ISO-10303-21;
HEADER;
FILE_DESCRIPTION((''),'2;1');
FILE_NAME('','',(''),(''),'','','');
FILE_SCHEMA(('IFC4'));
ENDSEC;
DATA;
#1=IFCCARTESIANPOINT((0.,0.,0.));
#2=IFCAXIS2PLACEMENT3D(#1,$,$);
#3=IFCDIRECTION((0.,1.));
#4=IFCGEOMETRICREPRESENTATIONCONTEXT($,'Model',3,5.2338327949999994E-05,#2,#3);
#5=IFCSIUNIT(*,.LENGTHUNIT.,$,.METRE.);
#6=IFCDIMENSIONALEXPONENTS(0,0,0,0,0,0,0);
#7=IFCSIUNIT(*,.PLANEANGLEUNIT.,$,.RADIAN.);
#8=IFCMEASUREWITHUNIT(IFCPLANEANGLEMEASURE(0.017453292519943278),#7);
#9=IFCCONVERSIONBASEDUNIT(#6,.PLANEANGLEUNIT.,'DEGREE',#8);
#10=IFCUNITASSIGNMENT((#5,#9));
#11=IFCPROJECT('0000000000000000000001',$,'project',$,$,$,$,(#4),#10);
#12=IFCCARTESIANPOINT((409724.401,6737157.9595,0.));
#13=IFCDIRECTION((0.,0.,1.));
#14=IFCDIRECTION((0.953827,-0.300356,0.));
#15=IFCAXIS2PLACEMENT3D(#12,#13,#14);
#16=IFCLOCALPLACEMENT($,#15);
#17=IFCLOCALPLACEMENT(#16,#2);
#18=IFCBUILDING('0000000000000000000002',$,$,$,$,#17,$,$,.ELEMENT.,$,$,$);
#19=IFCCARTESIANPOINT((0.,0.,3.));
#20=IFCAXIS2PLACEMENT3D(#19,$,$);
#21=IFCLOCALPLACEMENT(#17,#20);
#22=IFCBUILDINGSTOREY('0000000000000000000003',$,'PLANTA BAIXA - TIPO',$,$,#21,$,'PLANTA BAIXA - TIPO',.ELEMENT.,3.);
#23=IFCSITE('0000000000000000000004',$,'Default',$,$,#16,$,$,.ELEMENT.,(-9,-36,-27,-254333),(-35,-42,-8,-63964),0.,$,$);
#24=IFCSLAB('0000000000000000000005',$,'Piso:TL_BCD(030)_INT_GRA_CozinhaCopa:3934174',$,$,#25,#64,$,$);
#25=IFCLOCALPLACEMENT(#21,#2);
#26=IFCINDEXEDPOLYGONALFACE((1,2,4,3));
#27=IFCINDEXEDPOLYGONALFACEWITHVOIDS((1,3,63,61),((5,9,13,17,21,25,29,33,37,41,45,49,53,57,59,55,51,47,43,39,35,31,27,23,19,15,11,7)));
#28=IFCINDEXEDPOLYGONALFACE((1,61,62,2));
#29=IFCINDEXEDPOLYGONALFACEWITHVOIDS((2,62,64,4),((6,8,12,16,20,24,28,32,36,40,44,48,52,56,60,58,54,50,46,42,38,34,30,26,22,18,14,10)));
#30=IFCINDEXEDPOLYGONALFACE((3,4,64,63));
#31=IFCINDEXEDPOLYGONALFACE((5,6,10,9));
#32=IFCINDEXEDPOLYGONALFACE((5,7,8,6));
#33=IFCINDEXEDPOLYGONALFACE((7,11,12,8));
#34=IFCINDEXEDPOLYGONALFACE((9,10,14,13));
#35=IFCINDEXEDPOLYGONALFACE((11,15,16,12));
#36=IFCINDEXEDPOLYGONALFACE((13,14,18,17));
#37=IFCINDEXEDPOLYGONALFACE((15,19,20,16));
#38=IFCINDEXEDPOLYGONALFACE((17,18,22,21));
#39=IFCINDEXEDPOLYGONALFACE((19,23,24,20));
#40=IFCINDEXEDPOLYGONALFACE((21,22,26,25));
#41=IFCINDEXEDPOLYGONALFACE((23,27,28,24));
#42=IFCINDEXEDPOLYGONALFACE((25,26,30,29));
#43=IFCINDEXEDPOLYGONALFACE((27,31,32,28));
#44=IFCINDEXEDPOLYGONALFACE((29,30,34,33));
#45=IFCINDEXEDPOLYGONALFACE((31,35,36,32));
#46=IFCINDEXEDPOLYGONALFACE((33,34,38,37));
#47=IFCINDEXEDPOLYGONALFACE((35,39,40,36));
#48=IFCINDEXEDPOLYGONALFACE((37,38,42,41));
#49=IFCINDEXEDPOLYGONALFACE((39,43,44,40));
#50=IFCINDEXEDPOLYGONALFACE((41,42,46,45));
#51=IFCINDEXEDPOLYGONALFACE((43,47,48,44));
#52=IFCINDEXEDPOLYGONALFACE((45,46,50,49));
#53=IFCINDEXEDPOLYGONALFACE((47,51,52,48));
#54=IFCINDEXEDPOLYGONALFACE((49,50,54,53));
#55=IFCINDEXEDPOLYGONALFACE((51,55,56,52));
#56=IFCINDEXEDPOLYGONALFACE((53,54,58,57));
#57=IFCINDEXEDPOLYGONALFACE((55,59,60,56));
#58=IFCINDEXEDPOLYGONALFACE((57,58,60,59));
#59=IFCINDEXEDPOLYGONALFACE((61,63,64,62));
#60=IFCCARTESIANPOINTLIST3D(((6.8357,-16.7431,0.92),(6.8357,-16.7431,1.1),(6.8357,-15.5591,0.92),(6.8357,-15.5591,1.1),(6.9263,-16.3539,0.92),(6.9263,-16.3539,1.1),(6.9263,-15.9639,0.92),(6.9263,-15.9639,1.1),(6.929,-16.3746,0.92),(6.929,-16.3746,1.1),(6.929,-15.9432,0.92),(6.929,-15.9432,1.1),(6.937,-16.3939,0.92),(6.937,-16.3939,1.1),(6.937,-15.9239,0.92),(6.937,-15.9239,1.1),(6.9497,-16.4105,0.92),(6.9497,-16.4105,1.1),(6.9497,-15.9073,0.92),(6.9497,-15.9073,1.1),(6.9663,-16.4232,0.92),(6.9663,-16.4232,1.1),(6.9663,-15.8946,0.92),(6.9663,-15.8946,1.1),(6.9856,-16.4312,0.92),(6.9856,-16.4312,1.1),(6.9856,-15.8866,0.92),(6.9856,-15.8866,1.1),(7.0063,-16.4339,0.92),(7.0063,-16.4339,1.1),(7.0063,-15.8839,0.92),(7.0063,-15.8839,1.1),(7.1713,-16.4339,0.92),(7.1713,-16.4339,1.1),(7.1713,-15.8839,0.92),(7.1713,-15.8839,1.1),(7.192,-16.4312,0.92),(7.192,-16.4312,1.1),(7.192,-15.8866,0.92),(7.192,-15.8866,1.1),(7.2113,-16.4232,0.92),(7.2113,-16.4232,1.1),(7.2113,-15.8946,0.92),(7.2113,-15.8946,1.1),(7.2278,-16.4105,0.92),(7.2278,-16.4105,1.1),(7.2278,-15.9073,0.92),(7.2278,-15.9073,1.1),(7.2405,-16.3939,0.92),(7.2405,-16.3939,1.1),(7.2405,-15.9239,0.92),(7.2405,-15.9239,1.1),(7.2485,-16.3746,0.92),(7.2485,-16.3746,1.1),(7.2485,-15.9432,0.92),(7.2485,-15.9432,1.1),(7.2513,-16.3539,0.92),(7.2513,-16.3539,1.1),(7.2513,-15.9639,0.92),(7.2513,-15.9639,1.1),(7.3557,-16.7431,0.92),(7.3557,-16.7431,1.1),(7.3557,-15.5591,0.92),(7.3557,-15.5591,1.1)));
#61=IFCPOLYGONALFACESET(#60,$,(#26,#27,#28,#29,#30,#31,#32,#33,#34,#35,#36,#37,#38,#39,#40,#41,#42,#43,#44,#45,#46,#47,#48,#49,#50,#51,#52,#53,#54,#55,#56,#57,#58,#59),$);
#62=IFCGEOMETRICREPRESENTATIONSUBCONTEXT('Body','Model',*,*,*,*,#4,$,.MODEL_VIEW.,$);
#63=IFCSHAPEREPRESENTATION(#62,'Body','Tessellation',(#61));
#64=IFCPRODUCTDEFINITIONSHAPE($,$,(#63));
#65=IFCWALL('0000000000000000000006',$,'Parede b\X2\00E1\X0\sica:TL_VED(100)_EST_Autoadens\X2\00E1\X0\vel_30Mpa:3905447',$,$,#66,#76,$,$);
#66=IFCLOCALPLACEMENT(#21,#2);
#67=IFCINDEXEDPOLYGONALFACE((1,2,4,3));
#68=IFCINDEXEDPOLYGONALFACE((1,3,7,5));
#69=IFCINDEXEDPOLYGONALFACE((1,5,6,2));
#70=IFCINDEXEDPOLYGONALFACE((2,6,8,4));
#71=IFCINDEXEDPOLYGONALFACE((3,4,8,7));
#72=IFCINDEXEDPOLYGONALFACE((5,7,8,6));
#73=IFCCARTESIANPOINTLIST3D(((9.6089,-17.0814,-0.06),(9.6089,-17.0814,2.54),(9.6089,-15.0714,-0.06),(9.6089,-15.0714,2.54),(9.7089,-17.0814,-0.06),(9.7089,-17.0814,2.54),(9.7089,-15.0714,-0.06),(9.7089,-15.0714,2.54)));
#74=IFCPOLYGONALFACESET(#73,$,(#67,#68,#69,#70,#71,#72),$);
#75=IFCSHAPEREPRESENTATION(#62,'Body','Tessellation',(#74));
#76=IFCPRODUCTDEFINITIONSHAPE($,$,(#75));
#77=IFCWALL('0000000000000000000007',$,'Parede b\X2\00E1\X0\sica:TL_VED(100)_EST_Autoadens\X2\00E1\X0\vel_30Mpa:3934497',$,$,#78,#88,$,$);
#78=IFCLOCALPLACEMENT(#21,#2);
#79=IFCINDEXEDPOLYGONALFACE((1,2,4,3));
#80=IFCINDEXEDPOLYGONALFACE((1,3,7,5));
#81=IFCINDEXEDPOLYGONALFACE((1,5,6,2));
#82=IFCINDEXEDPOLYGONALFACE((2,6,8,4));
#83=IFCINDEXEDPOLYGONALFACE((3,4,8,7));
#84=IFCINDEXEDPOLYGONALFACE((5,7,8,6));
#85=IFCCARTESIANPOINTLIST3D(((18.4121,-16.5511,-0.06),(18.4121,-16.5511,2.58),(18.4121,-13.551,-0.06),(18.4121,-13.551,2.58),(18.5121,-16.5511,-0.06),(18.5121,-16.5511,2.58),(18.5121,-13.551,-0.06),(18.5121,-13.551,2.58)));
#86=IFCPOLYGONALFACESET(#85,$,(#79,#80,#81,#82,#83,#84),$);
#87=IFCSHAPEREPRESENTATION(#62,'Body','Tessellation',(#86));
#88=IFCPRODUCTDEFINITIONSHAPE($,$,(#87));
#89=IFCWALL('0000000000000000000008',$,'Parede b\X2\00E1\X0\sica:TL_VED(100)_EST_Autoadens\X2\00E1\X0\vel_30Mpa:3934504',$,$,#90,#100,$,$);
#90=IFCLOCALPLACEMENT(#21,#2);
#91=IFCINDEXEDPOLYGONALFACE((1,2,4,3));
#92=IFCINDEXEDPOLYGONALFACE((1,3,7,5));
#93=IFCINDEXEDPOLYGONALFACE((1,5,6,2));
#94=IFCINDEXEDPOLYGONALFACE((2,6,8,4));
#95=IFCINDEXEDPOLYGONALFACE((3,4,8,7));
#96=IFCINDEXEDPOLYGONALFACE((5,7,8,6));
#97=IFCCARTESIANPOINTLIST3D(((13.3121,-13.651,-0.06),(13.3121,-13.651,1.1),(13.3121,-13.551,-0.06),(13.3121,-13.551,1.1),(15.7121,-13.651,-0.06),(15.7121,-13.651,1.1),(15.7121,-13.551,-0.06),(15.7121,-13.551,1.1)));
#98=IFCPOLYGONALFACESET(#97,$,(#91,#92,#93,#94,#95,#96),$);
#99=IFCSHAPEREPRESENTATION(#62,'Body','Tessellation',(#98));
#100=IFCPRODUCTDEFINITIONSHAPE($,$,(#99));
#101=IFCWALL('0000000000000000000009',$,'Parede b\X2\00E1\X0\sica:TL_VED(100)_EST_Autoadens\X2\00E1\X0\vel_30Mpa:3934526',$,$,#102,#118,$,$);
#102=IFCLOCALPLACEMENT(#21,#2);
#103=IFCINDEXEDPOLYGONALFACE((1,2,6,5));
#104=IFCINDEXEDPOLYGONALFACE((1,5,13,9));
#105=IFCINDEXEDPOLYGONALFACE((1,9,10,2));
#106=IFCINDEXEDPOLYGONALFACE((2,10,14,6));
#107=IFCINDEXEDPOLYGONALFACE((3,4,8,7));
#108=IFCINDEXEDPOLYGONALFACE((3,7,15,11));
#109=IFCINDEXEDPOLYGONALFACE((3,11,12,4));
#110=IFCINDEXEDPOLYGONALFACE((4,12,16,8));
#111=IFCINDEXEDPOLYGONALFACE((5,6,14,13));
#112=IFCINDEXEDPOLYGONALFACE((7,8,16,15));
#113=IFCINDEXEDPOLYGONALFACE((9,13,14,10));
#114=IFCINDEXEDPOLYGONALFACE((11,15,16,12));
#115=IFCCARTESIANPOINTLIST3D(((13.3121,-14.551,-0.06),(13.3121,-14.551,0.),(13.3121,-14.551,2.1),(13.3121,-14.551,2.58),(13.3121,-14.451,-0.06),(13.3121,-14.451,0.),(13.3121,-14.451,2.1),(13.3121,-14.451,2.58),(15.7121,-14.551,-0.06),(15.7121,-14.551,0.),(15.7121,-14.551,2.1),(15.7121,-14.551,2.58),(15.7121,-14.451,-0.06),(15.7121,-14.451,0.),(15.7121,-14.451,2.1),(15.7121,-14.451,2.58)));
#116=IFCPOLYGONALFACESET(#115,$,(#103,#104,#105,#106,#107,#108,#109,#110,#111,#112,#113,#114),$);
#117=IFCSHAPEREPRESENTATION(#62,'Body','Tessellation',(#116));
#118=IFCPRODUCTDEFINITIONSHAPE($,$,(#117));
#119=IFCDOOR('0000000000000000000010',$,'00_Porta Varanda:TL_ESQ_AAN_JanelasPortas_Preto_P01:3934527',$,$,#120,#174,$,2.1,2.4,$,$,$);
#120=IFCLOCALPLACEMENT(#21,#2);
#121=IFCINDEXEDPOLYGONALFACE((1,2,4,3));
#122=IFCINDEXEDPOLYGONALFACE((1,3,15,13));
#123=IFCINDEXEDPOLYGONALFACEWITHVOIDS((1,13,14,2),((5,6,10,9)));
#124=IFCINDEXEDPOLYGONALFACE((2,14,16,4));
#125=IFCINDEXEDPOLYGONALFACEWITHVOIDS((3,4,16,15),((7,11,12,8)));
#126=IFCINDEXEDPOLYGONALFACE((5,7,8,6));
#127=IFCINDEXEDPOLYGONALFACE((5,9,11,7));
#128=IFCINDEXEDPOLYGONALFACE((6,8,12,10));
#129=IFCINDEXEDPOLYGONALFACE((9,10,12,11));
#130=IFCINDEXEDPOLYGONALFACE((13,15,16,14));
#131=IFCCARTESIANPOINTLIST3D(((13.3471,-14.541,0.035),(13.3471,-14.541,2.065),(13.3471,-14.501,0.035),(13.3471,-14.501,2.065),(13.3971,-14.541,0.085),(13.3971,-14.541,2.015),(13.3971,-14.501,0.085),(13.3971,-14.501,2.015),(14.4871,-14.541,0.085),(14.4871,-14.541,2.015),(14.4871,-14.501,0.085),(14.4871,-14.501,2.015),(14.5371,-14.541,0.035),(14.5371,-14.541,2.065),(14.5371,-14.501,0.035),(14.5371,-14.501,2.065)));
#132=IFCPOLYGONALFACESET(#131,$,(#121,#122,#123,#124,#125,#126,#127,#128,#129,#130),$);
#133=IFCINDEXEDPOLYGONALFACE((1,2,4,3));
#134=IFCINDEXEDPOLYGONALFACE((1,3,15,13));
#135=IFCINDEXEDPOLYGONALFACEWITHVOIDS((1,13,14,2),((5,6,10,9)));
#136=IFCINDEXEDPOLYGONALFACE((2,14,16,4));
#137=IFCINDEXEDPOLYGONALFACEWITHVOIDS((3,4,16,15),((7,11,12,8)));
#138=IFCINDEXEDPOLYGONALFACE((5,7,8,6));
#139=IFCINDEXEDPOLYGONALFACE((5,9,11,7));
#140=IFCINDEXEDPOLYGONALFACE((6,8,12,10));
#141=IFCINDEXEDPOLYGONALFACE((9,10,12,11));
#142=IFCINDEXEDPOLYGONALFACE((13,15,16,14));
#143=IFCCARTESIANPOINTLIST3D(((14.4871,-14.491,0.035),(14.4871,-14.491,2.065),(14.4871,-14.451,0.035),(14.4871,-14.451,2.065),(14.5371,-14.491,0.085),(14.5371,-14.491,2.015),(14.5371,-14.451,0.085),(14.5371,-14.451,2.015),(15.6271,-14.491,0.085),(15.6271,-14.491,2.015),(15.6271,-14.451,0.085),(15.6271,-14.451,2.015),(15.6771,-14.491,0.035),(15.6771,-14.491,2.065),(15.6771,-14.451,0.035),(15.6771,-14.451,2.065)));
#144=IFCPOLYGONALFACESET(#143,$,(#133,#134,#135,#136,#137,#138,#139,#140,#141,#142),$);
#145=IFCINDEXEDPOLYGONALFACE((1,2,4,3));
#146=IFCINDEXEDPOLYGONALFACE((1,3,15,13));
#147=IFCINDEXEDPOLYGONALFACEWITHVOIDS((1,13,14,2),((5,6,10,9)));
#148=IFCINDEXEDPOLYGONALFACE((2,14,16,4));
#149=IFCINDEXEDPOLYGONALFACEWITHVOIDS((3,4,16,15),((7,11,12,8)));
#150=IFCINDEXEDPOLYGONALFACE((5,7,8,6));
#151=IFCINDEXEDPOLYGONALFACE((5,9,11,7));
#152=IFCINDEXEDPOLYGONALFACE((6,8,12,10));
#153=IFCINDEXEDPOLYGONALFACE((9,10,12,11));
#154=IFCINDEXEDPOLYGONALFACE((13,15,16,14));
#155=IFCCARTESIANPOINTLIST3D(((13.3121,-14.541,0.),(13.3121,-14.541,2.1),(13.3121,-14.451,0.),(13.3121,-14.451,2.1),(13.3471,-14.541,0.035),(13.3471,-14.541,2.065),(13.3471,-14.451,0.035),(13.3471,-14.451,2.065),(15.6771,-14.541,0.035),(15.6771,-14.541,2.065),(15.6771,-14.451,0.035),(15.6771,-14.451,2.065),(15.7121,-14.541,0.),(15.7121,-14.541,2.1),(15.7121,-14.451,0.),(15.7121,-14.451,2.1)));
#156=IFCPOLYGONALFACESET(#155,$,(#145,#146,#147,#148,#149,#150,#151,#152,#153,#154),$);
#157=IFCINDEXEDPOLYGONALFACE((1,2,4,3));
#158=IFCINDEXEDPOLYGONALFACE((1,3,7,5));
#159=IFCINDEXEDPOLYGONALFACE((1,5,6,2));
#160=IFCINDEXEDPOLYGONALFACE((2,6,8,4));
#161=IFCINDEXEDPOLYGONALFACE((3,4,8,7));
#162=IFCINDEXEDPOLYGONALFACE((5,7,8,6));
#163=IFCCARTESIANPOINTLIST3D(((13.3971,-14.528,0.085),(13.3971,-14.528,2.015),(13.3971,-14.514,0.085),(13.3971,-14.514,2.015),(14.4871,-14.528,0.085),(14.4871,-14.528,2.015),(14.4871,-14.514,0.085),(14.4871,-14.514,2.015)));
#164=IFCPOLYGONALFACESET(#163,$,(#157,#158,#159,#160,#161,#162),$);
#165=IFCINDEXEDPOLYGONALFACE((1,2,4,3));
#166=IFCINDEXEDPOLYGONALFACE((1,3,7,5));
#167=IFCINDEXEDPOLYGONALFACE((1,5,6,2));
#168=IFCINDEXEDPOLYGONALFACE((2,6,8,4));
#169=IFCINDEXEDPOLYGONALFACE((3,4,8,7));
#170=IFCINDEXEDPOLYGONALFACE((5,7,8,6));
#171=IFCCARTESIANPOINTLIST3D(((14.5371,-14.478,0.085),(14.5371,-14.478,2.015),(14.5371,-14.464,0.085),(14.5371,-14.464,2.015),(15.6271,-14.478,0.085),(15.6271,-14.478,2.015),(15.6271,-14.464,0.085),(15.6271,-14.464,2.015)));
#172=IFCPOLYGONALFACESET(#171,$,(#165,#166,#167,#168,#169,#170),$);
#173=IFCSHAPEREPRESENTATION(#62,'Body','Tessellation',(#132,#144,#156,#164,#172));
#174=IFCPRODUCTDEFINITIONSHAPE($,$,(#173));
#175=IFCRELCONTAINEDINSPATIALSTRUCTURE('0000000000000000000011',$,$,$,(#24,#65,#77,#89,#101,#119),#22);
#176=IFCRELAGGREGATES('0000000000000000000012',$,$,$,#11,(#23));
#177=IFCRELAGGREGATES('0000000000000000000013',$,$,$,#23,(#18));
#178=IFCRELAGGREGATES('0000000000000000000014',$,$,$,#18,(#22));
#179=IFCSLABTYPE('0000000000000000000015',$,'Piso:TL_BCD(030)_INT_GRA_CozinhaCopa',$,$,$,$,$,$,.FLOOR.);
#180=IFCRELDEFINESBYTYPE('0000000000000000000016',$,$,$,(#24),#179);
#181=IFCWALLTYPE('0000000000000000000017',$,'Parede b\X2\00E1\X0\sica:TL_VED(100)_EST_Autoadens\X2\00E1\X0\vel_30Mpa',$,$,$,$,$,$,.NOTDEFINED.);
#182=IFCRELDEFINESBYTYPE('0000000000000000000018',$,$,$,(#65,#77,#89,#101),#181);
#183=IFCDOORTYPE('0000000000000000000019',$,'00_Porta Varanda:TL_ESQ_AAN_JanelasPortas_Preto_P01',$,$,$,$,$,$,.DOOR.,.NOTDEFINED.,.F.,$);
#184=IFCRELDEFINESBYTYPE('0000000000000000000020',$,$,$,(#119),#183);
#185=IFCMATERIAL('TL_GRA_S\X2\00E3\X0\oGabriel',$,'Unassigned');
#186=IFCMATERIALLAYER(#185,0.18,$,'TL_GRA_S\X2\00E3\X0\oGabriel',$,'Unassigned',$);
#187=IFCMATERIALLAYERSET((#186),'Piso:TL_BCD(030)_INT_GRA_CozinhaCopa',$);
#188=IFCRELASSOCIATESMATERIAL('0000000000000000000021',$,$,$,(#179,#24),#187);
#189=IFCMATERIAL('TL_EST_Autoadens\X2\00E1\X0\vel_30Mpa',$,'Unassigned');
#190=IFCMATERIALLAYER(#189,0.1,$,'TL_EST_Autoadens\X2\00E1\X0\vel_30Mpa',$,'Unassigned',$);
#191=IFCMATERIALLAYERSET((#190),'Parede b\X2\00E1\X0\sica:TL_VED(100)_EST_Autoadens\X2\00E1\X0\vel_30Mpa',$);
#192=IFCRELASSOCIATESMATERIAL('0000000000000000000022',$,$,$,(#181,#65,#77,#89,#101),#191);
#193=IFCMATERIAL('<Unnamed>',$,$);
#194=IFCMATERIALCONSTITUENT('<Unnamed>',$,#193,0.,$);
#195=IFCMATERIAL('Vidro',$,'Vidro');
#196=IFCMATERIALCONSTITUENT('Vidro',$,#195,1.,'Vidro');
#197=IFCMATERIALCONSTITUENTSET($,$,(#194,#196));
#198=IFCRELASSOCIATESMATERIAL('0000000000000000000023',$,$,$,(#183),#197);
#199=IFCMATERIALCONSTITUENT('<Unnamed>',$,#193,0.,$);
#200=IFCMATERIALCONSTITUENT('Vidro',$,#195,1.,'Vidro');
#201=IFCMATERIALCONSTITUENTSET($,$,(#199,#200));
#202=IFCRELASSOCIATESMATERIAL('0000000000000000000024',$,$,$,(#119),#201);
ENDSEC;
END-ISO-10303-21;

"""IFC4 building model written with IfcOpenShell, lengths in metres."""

from ifc_helpers import new_model, entity, si_unit, converted_unit, direction, frame, frame_2d, origin, place, context, subcontext, project, spatial, polyline, circle_curve, parameter, trimmed, segment, composite_curve, rectangle, outline, extrude, source, transform, mapped, material, layer, layer_set, layer_usage, constituent, constituent_set, type_object, type_shapes, element, fill, save


model = new_model("IFC4")

# Units and contexts
model_context = context("Model", 3, precision=5.2338327949999994e-05, world=origin(), true_north=direction((0.0, 1.0)))
body_context = subcontext(model_context, "Body", "Model", "MODEL_VIEW")
ifc_project = project(units=[si_unit("LENGTHUNIT", "METRE"), converted_unit("PLANEANGLEUNIT", "DEGREE", entity("IfcPlaneAngleMeasure", 0.017453292519943278), si_unit("PLANEANGLEUNIT", "RADIAN"), dimensions=[0, 0, 0, 0, 0, 0, 0])], contexts=[model_context])

# Site, building, storey
site_placement = place(None, frame((409724.401, 6737157.9595, 0.0), z_axis=(0.0, 0.0, 1.0), x_axis=(0.953827, -0.300356, 0.0)))
site = spatial("IfcSite", under=ifc_project, at=site_placement, Name="Default", CompositionType="ELEMENT", RefLatitude=(-9, -36, -27, -254333), RefLongitude=(-35, -42, -8, -63964), RefElevation=0.0)
building_placement = place(site_placement, origin())
building = spatial("IfcBuilding", under=site, at=building_placement, CompositionType="ELEMENT")
storey_placement = place(building_placement, frame((0.0, 0.0, 3.0)))
storey = spatial("IfcBuildingStorey", under=building, at=storey_placement, Name="PLANTA BAIXA - TIPO", LongName="PLANTA BAIXA - TIPO", CompositionType="ELEMENT", Elevation=3.0)

# Slab, opening
ifc_material_1 = material(Name="TL_GRA_SãoGabriel", Category="Unassigned")
ifc_layer_1 = layer(ifc_material_1, 0.18, Name="TL_GRA_SãoGabriel", Category="Unassigned")
ifc_layer_set_1 = layer_set([ifc_layer_1], Name="Piso:TL_BCD(030)_INT_GRA_CozinhaCopa")
ifc_layer_usage_1 = layer_usage(ifc_layer_set_1, "AXIS3", "POSITIVE", 0.0)
slab_type = type_object("IfcSlabType", Name="Piso:TL_BCD(030)_INT_GRA_CozinhaCopa", PredefinedType="FLOOR", material=ifc_layer_set_1)
slab_placement = place(storey_placement, frame((6.8357, -16.7431, 0.92)))
slab = element("IfcSlab", 1, at=slab_placement, inside=storey, type_object=slab_type, material=ifc_layer_usage_1, Name="Piso:TL_BCD(030)_INT_GRA_CozinhaCopa:3934174", context=body_context, shape_type="SweptSolid", body=[
    extrude(rectangle(XDim=1.184, YDim=0.52, at=frame_2d((0.0, 0.0), x_axis=(0.0, -1.0))), frame((0.26, 0.592, 0.18), z_axis=(0.0, 0.0, -1.0), x_axis=(-1.0, 0.0, 0.0)), (0.0, 0.0, 1.0), 0.18),
])
opening_1_placement = place(slab_placement, frame((-6.8357, 16.7431, 0.18)))
element("IfcOpeningElement", 2, at=opening_1_placement, cuts=slab, PredefinedType="OPENING", context=body_context, shape_type="SweptSolid", body=[
    extrude(outline(composite_curve([segment(polyline([(-0.195, -0.1625), (0.195, -0.1625)]), True, "CONTINUOUS"), segment(trimmed(circle_curve(frame_2d((0.195, -0.0825), x_axis=(-1.0, 0.0)), 0.08), [parameter(90.0)], [parameter(180.0)], True, "PARAMETER"), True, "CONTINUOUS"), segment(polyline([(0.275, -0.0825), (0.275, 0.0825)]), True, "CONTINUOUS"), segment(trimmed(circle_curve(frame_2d((0.195, 0.0825), x_axis=(-1.0, 0.0)), 0.08), [parameter(180.0)], [parameter(270.0)], True, "PARAMETER"), True, "CONTINUOUS"), segment(polyline([(0.195, 0.1625), (-0.195, 0.1625)]), True, "CONTINUOUS"), segment(trimmed(circle_curve(frame_2d((-0.195, 0.0825), x_axis=(-1.0, 0.0)), 0.08), [parameter(270.0)], [parameter(360.0)], True, "PARAMETER"), True, "CONTINUOUS"), segment(polyline([(-0.275, 0.0825), (-0.275, -0.0825)]), True, "CONTINUOUS"), segment(trimmed(circle_curve(frame_2d((-0.195, -0.0825), x_axis=(-1.0, 0.0)), 0.08), [parameter(360.0)], [parameter(90.0)], True, "PARAMETER"), True, "CONTINUOUS")], self_intersect=False)), frame((7.0888, -16.1589, -0.21), z_axis=(0.0, 0.0, 1.0), x_axis=(0.0, 1.0, 0.0)), (0.0, 0.0, 1.0), 0.21),
])

# Walls
ifc_material_2 = material(Name="TL_EST_Autoadensável_30Mpa", Category="Unassigned")
ifc_layer_2 = layer(ifc_material_2, 0.1, Name="TL_EST_Autoadensável_30Mpa", Category="Unassigned")
ifc_layer_set_2 = layer_set([ifc_layer_2], Name="Parede básica:TL_VED(100)_EST_Autoadensável_30Mpa")
ifc_layer_usage_2 = layer_usage(ifc_layer_set_2, "AXIS2", "NEGATIVE", 0.05)
wall_type_1 = type_object("IfcWallType", Name="Parede básica:TL_VED(100)_EST_Autoadensável_30Mpa", PredefinedType="NOTDEFINED", material=ifc_layer_set_2)
wall_1_placement = place(storey_placement, frame((9.6589, -15.0714, -0.06), z_axis=(0.0, 0.0, 1.0), x_axis=(0.0, -1.0, 0.0)))
element("IfcWall", 3, at=wall_1_placement, inside=storey, type_object=wall_type_1, material=ifc_layer_usage_2, Name="Parede básica:TL_VED(100)_EST_Autoadensável_30Mpa:3905447", context=body_context, shape_type="SweptSolid", body=[
    extrude(rectangle(XDim=2.01, YDim=0.1, at=frame_2d((1.005, 0.0), x_axis=(-1.0, 0.0))), origin(), (0.0, 0.0, 1.0), 2.6),
])
ifc_layer_usage_3 = layer_usage(ifc_layer_set_2, "AXIS2", "POSITIVE", -0.05)
wall_2_placement = place(storey_placement, frame((18.4621, -13.551, -0.06), z_axis=(0.0, 0.0, 1.0), x_axis=(0.0, -1.0, 0.0)))
element("IfcWall", 4, at=wall_2_placement, inside=storey, type_object=wall_type_1, material=ifc_layer_usage_3, Name="Parede básica:TL_VED(100)_EST_Autoadensável_30Mpa:3934497", context=body_context, shape_type="SweptSolid", body=[
    extrude(rectangle(XDim=3.0001, YDim=0.1, at=frame_2d((1.5001, 0.0), x_axis=(-1.0, 0.0))), origin(), (0.0, 0.0, 1.0), 2.64),
])

# Wall
ifc_layer_usage_4 = layer_usage(ifc_layer_set_2, "AXIS2", "POSITIVE", -0.05)
wall_3_placement = place(storey_placement, frame((15.7121, -13.601, -0.06), z_axis=(0.0, 0.0, 1.0), x_axis=(-1.0, 0.0, 0.0)))
element("IfcWall", 5, at=wall_3_placement, inside=storey, type_object=wall_type_1, material=ifc_layer_usage_4, Name="Parede básica:TL_VED(100)_EST_Autoadensável_30Mpa:3934504", context=body_context, shape_type="SweptSolid", body=[
    extrude(rectangle(XDim=2.4, YDim=0.1, at=frame_2d((1.2, 0.0), x_axis=(-1.0, 0.0))), origin(), (0.0, 0.0, 1.0), 1.16),
])

# Wall, opening, door
ifc_layer_usage_5 = layer_usage(ifc_layer_set_2, "AXIS2", "POSITIVE", -0.05)
wall_4_placement = place(storey_placement, frame((15.7121, -14.501, -0.06), z_axis=(0.0, 0.0, 1.0), x_axis=(-1.0, 0.0, 0.0)))
wall_4 = element("IfcWall", 6, at=wall_4_placement, inside=storey, type_object=wall_type_1, material=ifc_layer_usage_5, Name="Parede básica:TL_VED(100)_EST_Autoadensável_30Mpa:3934526", context=body_context, shape_type="SweptSolid", body=[
    extrude(rectangle(XDim=2.4, YDim=0.1, at=frame_2d((1.2, 0.0), x_axis=(-1.0, 0.0))), origin(), (0.0, 0.0, 1.0), 2.64),
])
opening_2_placement = place(wall_4_placement, frame((0.0, -0.05, 0.06)))
opening_2 = element("IfcOpeningElement", 7, at=opening_2_placement, cuts=wall_4, PredefinedType="OPENING", context=body_context, shape_type="SweptSolid", body=[
    extrude(rectangle(XDim=2.1, YDim=2.4, at=frame_2d((1.05, 1.2), x_axis=(1.0, 0.0))), frame((0.0, 0.0, 0.0), z_axis=(0.0, 1.0, 0.0), x_axis=(0.0, 0.0, 1.0)), (0.0, 0.0, 1.0), 0.1),
])
ifc_material_3 = material(Name="<Unnamed>")
ifc_constituent_1 = constituent(ifc_material_3, Name="<Unnamed>", fraction=0.0)
ifc_material_4 = material(Name="Vidro", Category="Vidro")
ifc_constituent_2 = constituent(ifc_material_4, Name="Vidro", Category="Vidro", fraction=1.0)
ifc_constituent_set_1 = constituent_set(constituents=[ifc_constituent_1, ifc_constituent_2])
ifc_constituent_3 = constituent(ifc_material_3, Name="<Unnamed>", fraction=0.0)
ifc_constituent_4 = constituent(ifc_material_4, Name="Vidro", Category="Vidro", fraction=1.0)
ifc_constituent_set_2 = constituent_set(constituents=[ifc_constituent_3, ifc_constituent_4])
door_type = type_object("IfcDoorType", Name="00_Porta Varanda:TL_ESQ_AAN_JanelasPortas_Preto_P01", OperationType="NOTDEFINED", ParameterTakesPrecedence=False, PredefinedType="DOOR", material=ifc_constituent_set_2)
shared_shape_1 = source(origin(), body_context, "Body", "SweptSolid", [
    extrude(outline(polyline([(-1.015, -0.595), (1.015, -0.595), (1.015, 0.595), (-1.015, 0.595), (-1.015, -0.595)]), holes=[polyline([(0.965, -0.545), (-0.965, -0.545), (-0.965, 0.545), (0.965, 0.545), (0.965, -0.545)])]), frame((1.77, 0.05, 1.05), z_axis=(0.0, 1.0, 0.0), x_axis=(0.0, 0.0, 1.0)), (0.0, 0.0, 1.0), 0.04),
    extrude(outline(polyline([(-1.015, -0.595), (1.015, -0.595), (1.015, 0.595), (-1.015, 0.595), (-1.015, -0.595)]), holes=[polyline([(0.965, -0.545), (-0.965, -0.545), (-0.965, 0.545), (0.965, 0.545), (0.965, -0.545)])]), frame((0.63, 0.0, 1.05), z_axis=(0.0, 1.0, 0.0), x_axis=(0.0, 0.0, -1.0)), (0.0, 0.0, 1.0), 0.04),
    extrude(outline(polyline([(-1.05, -1.2), (1.05, -1.2), (1.05, 1.2), (-1.05, 1.2), (-1.05, -1.2)]), holes=[polyline([(1.015, -1.165), (-1.015, -1.165), (-1.015, 1.165), (1.015, 1.165), (1.015, -1.165)])]), frame((1.2, 0.0, 1.05), z_axis=(0.0, 1.0, 0.0), x_axis=(0.0, 0.0, -1.0)), (0.0, 0.0, 1.0), 0.09),
    extrude(rectangle(XDim=0.014, YDim=1.09, at=frame_2d((0.0, 0.0), x_axis=(1.0, 0.0))), frame((1.77, 0.07, 0.085), z_axis=(0.0, 0.0, 1.0), x_axis=(0.0, -1.0, 0.0)), (0.0, 0.0, 1.0), 1.93),
    extrude(rectangle(XDim=0.014, YDim=1.09, at=frame_2d((0.0, 0.0), x_axis=(1.0, 0.0))), frame((0.63, 0.02, 0.085), z_axis=(0.0, 0.0, 1.0), x_axis=(0.0, -1.0, 0.0)), (0.0, 0.0, 1.0), 1.93),
])
type_shapes(door_type, [shared_shape_1])
door_placement = place(opening_2_placement, origin())
door = element("IfcDoor", 8, at=door_placement, inside=storey, type_object=door_type, material=ifc_constituent_set_1, Name="00_Porta Varanda:TL_ESQ_AAN_JanelasPortas_Preto_P01:3934527", OverallHeight=2.1, OverallWidth=2.4, context=body_context, shape_type="MappedRepresentation", body=[
    mapped(shared_shape_1, transform((0.0, 0.0, 0.0), scale=1.0)),
])
fill(opening_2, door)

save(model, "model.ifc")
